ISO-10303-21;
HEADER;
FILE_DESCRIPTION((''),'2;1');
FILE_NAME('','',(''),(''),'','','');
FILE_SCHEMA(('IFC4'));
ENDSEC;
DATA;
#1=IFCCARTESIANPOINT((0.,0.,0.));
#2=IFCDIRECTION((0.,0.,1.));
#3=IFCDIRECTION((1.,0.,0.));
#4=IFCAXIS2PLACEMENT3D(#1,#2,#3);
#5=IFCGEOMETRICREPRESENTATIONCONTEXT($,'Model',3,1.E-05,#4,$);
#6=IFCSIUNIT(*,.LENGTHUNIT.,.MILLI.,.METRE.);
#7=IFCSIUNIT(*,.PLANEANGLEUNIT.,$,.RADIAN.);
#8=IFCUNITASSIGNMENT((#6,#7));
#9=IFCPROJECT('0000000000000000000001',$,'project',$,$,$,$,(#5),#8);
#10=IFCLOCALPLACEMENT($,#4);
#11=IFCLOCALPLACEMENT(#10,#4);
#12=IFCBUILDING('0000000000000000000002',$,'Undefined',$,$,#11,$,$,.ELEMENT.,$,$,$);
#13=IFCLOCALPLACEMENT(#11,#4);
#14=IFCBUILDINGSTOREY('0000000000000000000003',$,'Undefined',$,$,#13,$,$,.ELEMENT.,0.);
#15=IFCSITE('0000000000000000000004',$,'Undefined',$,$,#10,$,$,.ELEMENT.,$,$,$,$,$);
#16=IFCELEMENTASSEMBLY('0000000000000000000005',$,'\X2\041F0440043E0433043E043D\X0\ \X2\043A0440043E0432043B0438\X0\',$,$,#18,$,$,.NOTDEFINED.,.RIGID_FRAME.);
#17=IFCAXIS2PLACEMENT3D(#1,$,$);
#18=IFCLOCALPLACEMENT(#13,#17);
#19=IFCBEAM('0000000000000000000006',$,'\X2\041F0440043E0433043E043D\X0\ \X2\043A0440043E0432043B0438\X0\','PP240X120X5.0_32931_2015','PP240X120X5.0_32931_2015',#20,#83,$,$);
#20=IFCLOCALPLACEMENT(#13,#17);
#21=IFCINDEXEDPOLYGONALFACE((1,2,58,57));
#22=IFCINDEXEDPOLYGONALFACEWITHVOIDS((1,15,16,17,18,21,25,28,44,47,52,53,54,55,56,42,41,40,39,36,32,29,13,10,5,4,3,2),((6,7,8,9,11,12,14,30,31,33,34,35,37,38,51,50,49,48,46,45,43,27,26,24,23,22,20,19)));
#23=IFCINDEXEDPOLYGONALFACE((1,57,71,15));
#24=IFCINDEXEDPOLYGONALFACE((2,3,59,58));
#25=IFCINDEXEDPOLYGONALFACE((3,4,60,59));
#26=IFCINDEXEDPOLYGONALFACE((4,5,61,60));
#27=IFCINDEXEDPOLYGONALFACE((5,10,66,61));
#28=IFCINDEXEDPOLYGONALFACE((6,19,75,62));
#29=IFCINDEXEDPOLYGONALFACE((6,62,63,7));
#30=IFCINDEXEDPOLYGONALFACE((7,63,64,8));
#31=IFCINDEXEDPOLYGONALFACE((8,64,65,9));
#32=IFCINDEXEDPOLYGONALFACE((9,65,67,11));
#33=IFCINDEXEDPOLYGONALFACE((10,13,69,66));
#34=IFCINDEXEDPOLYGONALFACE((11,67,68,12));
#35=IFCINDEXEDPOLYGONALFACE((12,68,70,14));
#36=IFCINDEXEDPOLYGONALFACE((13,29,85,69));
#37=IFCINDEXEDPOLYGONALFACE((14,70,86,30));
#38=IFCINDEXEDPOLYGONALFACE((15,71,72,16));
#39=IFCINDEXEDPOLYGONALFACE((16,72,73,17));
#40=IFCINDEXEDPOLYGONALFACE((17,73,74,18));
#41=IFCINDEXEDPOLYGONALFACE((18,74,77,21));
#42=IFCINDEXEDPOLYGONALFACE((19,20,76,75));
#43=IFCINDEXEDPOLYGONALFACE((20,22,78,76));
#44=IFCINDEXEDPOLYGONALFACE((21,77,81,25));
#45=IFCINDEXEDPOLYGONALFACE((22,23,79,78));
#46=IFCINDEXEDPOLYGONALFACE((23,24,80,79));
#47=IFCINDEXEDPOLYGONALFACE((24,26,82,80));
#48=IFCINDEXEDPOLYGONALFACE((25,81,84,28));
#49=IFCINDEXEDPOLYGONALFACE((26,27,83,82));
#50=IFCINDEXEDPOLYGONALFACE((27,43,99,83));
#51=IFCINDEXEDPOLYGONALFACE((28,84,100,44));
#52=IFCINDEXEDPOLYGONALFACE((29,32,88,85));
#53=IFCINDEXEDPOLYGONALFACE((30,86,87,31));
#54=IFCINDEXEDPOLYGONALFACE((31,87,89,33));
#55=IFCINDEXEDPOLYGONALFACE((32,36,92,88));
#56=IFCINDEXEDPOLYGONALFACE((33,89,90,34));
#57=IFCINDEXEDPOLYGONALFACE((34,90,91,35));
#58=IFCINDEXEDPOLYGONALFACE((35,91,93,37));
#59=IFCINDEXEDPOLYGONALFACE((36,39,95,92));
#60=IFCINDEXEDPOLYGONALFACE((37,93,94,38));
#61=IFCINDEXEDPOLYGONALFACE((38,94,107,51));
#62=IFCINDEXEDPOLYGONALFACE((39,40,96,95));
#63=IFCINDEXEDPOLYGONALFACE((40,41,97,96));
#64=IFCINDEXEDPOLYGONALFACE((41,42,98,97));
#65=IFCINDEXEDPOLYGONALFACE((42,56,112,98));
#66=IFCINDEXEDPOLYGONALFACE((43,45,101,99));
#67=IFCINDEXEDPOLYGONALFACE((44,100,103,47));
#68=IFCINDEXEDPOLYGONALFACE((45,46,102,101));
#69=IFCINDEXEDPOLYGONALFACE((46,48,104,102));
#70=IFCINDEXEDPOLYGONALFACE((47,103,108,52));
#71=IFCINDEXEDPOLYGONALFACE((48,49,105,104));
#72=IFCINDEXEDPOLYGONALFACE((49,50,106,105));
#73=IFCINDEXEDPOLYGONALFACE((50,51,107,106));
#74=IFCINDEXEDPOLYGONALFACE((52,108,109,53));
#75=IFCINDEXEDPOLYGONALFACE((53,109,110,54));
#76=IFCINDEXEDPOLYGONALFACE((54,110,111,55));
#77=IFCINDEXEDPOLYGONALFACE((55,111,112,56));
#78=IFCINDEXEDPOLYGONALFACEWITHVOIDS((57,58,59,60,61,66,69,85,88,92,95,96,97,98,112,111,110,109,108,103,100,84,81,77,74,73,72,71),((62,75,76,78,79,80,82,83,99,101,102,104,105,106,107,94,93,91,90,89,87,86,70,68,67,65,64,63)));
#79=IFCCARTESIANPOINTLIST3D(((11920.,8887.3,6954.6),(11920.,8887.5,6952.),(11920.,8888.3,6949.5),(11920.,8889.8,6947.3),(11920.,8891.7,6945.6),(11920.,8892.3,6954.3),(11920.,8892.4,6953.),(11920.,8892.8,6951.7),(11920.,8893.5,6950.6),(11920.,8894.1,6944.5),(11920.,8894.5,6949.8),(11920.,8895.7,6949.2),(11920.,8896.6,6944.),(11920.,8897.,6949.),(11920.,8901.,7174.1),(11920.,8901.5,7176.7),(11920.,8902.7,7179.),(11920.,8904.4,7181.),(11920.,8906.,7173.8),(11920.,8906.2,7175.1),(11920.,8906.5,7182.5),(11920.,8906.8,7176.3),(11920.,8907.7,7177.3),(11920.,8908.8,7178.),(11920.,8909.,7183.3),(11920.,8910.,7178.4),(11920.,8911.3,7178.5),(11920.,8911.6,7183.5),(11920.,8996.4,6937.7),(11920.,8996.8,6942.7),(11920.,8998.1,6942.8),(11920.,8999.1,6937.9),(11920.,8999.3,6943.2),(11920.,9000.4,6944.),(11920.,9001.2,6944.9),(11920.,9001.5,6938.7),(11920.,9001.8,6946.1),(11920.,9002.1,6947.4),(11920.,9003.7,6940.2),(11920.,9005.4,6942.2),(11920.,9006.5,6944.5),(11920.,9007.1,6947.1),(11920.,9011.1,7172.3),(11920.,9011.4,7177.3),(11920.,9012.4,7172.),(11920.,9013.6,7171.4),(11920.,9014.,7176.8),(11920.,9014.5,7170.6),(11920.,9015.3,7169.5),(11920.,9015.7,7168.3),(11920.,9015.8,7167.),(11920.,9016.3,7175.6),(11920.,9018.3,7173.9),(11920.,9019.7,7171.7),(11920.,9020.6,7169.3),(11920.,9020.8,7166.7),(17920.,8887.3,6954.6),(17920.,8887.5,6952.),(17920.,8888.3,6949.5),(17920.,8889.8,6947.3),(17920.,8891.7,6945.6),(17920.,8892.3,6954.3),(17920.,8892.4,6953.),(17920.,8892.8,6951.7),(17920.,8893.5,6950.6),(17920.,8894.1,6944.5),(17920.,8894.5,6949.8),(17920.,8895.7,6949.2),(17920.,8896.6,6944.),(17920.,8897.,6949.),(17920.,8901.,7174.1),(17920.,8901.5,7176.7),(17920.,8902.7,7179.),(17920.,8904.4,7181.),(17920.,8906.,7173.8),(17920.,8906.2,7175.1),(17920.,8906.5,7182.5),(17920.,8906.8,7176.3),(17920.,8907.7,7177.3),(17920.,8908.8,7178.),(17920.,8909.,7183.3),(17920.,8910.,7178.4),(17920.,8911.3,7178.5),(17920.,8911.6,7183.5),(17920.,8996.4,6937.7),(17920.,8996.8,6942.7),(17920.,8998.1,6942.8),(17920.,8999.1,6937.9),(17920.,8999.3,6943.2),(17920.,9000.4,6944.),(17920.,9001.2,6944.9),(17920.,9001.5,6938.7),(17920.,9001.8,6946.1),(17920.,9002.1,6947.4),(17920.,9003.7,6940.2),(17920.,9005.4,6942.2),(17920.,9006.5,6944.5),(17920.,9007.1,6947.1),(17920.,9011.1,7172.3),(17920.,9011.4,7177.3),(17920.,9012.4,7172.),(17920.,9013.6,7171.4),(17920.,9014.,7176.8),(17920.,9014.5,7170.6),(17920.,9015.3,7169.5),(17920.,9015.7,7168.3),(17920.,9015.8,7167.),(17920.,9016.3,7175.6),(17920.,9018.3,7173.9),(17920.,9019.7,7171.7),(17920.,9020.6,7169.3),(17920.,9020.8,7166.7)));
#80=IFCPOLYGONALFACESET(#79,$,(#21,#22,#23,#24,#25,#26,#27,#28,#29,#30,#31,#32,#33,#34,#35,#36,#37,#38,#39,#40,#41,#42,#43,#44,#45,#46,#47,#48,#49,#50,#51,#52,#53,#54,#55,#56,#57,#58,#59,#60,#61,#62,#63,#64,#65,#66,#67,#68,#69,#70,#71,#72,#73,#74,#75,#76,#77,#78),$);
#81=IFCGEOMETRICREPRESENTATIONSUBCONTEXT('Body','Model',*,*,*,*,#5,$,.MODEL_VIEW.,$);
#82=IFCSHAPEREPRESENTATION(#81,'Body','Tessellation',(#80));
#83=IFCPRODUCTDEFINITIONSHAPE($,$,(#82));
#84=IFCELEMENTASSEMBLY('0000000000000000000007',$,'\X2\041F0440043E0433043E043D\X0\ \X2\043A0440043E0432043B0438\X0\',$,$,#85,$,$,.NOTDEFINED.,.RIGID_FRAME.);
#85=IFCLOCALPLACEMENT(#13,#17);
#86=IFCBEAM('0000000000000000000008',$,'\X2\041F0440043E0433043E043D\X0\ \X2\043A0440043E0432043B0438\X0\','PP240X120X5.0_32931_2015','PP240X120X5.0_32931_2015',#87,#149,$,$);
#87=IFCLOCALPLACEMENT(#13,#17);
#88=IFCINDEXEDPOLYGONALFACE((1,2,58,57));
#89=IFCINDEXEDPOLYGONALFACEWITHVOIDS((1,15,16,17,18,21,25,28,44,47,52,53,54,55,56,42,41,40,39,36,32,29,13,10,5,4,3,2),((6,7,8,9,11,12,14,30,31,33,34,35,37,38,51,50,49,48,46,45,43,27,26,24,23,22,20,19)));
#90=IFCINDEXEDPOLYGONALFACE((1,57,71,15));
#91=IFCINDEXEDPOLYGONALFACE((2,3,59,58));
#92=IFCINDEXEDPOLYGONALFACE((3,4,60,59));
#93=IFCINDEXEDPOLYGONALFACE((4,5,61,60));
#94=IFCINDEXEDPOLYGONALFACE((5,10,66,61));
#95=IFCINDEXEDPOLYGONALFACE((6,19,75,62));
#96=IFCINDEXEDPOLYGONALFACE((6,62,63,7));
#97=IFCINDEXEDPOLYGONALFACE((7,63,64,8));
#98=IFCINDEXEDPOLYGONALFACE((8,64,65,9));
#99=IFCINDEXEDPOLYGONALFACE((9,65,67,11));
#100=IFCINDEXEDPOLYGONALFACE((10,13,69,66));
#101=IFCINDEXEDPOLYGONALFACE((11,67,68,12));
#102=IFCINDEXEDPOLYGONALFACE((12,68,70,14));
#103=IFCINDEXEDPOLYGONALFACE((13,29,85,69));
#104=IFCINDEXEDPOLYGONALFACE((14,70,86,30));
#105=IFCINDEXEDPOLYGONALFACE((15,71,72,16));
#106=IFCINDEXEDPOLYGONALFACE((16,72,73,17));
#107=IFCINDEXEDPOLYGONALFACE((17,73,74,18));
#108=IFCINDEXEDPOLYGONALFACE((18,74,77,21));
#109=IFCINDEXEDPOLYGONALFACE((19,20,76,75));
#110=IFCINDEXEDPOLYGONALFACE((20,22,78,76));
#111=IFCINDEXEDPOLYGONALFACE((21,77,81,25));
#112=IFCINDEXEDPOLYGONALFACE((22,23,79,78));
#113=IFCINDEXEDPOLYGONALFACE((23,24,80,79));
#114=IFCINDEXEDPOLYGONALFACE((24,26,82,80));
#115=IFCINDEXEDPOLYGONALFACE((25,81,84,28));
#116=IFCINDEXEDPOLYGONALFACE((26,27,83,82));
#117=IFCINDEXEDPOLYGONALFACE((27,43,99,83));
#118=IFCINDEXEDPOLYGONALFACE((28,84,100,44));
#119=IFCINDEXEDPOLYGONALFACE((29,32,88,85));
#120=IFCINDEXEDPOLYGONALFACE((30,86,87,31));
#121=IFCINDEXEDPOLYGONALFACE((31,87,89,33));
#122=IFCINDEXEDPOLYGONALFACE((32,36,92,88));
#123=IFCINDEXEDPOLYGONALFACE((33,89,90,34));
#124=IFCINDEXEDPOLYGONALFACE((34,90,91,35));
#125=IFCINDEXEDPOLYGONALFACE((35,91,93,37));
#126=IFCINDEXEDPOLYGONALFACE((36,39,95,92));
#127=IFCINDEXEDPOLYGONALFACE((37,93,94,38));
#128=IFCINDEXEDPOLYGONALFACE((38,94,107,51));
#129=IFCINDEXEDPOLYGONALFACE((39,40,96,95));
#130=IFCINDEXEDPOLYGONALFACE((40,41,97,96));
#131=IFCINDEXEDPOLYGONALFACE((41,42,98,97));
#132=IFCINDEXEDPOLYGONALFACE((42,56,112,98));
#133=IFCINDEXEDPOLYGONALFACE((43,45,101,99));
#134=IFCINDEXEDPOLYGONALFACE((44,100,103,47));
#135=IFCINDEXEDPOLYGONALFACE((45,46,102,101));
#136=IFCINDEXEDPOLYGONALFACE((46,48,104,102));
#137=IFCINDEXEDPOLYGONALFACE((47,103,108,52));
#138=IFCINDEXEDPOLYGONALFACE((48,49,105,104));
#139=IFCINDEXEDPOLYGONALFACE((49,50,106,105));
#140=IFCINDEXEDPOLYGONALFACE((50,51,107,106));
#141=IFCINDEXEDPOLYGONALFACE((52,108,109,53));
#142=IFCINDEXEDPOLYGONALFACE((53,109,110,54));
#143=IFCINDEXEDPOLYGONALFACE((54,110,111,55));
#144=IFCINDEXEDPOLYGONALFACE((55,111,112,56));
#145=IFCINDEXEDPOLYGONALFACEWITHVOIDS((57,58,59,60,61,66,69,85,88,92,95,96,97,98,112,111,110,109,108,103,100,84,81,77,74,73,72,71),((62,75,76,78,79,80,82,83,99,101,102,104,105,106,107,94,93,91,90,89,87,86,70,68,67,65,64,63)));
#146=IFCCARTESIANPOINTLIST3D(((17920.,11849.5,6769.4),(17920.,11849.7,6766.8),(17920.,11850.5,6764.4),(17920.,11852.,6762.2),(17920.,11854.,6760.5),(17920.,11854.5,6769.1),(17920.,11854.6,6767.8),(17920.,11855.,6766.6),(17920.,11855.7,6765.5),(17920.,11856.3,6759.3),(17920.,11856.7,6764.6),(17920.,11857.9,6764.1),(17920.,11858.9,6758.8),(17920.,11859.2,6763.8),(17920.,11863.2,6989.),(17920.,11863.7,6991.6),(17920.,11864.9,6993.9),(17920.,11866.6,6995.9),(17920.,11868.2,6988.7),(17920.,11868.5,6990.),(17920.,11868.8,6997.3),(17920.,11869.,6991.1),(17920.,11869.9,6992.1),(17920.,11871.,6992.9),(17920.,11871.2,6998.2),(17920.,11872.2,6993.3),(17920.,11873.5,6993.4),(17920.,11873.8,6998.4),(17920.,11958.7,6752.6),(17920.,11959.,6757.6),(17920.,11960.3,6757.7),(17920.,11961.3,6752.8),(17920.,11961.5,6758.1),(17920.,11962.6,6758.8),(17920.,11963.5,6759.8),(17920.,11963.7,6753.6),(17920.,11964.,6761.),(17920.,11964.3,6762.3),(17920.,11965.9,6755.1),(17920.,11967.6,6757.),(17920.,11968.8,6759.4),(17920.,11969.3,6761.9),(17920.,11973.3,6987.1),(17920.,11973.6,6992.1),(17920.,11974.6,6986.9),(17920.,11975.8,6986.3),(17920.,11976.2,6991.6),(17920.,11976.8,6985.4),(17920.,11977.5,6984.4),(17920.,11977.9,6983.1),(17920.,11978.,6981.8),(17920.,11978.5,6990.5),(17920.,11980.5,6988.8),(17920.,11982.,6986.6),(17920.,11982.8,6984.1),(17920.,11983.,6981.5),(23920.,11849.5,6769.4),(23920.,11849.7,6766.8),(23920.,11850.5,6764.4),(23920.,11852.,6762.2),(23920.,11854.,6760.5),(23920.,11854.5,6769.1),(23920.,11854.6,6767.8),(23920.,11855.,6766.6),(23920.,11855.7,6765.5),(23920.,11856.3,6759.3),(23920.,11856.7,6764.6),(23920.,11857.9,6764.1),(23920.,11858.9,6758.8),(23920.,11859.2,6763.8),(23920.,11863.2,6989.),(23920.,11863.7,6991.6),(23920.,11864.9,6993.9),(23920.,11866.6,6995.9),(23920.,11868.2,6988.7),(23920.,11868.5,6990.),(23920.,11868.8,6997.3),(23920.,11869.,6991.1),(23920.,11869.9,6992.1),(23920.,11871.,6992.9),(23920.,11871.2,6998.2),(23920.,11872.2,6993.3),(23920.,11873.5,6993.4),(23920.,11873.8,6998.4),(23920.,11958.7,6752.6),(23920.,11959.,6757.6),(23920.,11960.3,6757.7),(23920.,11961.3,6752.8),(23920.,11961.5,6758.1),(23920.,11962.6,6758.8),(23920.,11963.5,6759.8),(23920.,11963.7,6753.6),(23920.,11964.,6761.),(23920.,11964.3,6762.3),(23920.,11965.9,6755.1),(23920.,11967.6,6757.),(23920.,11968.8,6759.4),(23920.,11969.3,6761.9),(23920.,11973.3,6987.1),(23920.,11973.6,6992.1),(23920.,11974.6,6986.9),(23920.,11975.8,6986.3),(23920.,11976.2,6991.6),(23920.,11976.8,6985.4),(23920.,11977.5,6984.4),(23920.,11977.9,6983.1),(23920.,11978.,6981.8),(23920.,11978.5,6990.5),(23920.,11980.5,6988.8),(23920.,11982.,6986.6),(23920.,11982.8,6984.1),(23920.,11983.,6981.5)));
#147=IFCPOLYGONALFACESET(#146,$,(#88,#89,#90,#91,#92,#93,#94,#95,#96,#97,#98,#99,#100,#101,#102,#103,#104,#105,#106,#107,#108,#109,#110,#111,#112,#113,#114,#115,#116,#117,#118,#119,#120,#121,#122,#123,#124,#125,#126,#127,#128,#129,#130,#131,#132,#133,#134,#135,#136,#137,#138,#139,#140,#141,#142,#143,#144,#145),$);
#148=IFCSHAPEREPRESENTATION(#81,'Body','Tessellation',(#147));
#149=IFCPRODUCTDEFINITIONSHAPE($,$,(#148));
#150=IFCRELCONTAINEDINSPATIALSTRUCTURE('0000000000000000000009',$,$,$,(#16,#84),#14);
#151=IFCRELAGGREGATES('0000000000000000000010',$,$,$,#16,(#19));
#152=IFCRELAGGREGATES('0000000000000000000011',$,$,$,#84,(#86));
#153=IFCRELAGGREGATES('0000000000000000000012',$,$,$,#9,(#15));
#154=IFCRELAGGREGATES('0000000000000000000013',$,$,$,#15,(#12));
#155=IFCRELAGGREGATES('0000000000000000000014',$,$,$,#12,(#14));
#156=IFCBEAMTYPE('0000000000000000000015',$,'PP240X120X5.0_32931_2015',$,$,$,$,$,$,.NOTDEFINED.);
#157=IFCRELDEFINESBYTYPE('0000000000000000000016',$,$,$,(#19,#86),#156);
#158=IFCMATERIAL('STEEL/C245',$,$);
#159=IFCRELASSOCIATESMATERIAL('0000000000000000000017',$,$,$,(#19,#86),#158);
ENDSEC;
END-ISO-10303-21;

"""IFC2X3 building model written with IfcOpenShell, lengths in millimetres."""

from ifc_helpers import new_model, si_unit, frame, origin_with_axes, origin_2d_with_axis, place, context, subcontext, project, spatial, hollow_rectangle, extrude, material, type_object, element, aggregate, save


model = new_model("IFC2X3")

# Units and contexts
model_context = context("Model", 3, precision=1e-05, world=origin_with_axes())
body_context = subcontext(model_context, "Body", "Model", "MODEL_VIEW")
ifc_project = project(units=[si_unit("LENGTHUNIT", "METRE", prefix="MILLI"), si_unit("PLANEANGLEUNIT", "RADIAN")], contexts=[model_context])

# Site, building, storey
site_placement = place(None, origin_with_axes())
site = spatial("IfcSite", under=ifc_project, at=site_placement, Name="Undefined", CompositionType="ELEMENT")
building_placement = place(site_placement, origin_with_axes())
building = spatial("IfcBuilding", under=site, at=building_placement, Name="Undefined", CompositionType="ELEMENT")
storey_placement = place(building_placement, origin_with_axes())
storey = spatial("IfcBuildingStorey", under=building, at=storey_placement, Name="Undefined", CompositionType="ELEMENT", Elevation=0.0)

# Shared definitions
ifc_material = material(Name="STEEL/C245")

# Element assemblies, beams
beam_type_1 = type_object("IfcBeamType", Name="PP240X120X5.0_32931_2015", PredefinedType="NOTDEFINED")
assembly_1_placement = place(storey_placement, origin_with_axes())
assembly_1 = element("IfcElementAssembly", 1, at=assembly_1_placement, inside=storey, Name="Прогон кровли", AssemblyPlace="NOTDEFINED", PredefinedType="RIGID_FRAME")
beam_1_placement = place(assembly_1_placement, frame((17920.0, 8954.0, 7060.6), z_axis=(0.0, 0.062378, 0.998053), x_axis=(-1.0, 0.0, 0.0)))
beam_1 = element("IfcBeam", 2, at=beam_1_placement, type_object=beam_type_1, material=ifc_material, Name="Прогон кровли", Description="PP240X120X5.0_32931_2015", ObjectType="PP240X120X5.0_32931_2015", context=body_context, shape_type="SweptSolid", body=[
    extrude(hollow_rectangle(XDim=120.0, YDim=240.0, WallThickness=5.0, InnerFilletRadius=5.0, OuterFilletRadius=10.0, at=origin_2d_with_axis()), frame((6000.0, 0.0, 0.0), z_axis=(-1.0, 0.0, 0.0), x_axis=(0.0, -1.0, 0.0)), (0.0, 0.0, 1.0), 6000.0),
])
aggregate(assembly_1, [beam_1])
assembly_2_placement = place(storey_placement, origin_with_axes())
assembly_2 = element("IfcElementAssembly", 3, at=assembly_2_placement, inside=storey, Name="Прогон кровли", AssemblyPlace="NOTDEFINED", PredefinedType="RIGID_FRAME")
beam_2_placement = place(assembly_2_placement, frame((23920.0, 11916.2, 6875.5), z_axis=(0.0, 0.062378, 0.998053), x_axis=(-1.0, 0.0, 0.0)))
beam_2 = element("IfcBeam", 4, at=beam_2_placement, type_object=beam_type_1, material=ifc_material, Name="Прогон кровли", Description="PP240X120X5.0_32931_2015", ObjectType="PP240X120X5.0_32931_2015", context=body_context, shape_type="SweptSolid", body=[
    extrude(hollow_rectangle(XDim=120.0, YDim=240.0, WallThickness=5.0, InnerFilletRadius=5.0, OuterFilletRadius=10.0, at=origin_2d_with_axis()), frame((6000.0, 0.0, 0.0), z_axis=(-1.0, 0.0, 0.0), x_axis=(0.0, -1.0, 0.0)), (0.0, 0.0, 1.0), 6000.0),
])
aggregate(assembly_2, [beam_2])

save(model, "model.ifc")
